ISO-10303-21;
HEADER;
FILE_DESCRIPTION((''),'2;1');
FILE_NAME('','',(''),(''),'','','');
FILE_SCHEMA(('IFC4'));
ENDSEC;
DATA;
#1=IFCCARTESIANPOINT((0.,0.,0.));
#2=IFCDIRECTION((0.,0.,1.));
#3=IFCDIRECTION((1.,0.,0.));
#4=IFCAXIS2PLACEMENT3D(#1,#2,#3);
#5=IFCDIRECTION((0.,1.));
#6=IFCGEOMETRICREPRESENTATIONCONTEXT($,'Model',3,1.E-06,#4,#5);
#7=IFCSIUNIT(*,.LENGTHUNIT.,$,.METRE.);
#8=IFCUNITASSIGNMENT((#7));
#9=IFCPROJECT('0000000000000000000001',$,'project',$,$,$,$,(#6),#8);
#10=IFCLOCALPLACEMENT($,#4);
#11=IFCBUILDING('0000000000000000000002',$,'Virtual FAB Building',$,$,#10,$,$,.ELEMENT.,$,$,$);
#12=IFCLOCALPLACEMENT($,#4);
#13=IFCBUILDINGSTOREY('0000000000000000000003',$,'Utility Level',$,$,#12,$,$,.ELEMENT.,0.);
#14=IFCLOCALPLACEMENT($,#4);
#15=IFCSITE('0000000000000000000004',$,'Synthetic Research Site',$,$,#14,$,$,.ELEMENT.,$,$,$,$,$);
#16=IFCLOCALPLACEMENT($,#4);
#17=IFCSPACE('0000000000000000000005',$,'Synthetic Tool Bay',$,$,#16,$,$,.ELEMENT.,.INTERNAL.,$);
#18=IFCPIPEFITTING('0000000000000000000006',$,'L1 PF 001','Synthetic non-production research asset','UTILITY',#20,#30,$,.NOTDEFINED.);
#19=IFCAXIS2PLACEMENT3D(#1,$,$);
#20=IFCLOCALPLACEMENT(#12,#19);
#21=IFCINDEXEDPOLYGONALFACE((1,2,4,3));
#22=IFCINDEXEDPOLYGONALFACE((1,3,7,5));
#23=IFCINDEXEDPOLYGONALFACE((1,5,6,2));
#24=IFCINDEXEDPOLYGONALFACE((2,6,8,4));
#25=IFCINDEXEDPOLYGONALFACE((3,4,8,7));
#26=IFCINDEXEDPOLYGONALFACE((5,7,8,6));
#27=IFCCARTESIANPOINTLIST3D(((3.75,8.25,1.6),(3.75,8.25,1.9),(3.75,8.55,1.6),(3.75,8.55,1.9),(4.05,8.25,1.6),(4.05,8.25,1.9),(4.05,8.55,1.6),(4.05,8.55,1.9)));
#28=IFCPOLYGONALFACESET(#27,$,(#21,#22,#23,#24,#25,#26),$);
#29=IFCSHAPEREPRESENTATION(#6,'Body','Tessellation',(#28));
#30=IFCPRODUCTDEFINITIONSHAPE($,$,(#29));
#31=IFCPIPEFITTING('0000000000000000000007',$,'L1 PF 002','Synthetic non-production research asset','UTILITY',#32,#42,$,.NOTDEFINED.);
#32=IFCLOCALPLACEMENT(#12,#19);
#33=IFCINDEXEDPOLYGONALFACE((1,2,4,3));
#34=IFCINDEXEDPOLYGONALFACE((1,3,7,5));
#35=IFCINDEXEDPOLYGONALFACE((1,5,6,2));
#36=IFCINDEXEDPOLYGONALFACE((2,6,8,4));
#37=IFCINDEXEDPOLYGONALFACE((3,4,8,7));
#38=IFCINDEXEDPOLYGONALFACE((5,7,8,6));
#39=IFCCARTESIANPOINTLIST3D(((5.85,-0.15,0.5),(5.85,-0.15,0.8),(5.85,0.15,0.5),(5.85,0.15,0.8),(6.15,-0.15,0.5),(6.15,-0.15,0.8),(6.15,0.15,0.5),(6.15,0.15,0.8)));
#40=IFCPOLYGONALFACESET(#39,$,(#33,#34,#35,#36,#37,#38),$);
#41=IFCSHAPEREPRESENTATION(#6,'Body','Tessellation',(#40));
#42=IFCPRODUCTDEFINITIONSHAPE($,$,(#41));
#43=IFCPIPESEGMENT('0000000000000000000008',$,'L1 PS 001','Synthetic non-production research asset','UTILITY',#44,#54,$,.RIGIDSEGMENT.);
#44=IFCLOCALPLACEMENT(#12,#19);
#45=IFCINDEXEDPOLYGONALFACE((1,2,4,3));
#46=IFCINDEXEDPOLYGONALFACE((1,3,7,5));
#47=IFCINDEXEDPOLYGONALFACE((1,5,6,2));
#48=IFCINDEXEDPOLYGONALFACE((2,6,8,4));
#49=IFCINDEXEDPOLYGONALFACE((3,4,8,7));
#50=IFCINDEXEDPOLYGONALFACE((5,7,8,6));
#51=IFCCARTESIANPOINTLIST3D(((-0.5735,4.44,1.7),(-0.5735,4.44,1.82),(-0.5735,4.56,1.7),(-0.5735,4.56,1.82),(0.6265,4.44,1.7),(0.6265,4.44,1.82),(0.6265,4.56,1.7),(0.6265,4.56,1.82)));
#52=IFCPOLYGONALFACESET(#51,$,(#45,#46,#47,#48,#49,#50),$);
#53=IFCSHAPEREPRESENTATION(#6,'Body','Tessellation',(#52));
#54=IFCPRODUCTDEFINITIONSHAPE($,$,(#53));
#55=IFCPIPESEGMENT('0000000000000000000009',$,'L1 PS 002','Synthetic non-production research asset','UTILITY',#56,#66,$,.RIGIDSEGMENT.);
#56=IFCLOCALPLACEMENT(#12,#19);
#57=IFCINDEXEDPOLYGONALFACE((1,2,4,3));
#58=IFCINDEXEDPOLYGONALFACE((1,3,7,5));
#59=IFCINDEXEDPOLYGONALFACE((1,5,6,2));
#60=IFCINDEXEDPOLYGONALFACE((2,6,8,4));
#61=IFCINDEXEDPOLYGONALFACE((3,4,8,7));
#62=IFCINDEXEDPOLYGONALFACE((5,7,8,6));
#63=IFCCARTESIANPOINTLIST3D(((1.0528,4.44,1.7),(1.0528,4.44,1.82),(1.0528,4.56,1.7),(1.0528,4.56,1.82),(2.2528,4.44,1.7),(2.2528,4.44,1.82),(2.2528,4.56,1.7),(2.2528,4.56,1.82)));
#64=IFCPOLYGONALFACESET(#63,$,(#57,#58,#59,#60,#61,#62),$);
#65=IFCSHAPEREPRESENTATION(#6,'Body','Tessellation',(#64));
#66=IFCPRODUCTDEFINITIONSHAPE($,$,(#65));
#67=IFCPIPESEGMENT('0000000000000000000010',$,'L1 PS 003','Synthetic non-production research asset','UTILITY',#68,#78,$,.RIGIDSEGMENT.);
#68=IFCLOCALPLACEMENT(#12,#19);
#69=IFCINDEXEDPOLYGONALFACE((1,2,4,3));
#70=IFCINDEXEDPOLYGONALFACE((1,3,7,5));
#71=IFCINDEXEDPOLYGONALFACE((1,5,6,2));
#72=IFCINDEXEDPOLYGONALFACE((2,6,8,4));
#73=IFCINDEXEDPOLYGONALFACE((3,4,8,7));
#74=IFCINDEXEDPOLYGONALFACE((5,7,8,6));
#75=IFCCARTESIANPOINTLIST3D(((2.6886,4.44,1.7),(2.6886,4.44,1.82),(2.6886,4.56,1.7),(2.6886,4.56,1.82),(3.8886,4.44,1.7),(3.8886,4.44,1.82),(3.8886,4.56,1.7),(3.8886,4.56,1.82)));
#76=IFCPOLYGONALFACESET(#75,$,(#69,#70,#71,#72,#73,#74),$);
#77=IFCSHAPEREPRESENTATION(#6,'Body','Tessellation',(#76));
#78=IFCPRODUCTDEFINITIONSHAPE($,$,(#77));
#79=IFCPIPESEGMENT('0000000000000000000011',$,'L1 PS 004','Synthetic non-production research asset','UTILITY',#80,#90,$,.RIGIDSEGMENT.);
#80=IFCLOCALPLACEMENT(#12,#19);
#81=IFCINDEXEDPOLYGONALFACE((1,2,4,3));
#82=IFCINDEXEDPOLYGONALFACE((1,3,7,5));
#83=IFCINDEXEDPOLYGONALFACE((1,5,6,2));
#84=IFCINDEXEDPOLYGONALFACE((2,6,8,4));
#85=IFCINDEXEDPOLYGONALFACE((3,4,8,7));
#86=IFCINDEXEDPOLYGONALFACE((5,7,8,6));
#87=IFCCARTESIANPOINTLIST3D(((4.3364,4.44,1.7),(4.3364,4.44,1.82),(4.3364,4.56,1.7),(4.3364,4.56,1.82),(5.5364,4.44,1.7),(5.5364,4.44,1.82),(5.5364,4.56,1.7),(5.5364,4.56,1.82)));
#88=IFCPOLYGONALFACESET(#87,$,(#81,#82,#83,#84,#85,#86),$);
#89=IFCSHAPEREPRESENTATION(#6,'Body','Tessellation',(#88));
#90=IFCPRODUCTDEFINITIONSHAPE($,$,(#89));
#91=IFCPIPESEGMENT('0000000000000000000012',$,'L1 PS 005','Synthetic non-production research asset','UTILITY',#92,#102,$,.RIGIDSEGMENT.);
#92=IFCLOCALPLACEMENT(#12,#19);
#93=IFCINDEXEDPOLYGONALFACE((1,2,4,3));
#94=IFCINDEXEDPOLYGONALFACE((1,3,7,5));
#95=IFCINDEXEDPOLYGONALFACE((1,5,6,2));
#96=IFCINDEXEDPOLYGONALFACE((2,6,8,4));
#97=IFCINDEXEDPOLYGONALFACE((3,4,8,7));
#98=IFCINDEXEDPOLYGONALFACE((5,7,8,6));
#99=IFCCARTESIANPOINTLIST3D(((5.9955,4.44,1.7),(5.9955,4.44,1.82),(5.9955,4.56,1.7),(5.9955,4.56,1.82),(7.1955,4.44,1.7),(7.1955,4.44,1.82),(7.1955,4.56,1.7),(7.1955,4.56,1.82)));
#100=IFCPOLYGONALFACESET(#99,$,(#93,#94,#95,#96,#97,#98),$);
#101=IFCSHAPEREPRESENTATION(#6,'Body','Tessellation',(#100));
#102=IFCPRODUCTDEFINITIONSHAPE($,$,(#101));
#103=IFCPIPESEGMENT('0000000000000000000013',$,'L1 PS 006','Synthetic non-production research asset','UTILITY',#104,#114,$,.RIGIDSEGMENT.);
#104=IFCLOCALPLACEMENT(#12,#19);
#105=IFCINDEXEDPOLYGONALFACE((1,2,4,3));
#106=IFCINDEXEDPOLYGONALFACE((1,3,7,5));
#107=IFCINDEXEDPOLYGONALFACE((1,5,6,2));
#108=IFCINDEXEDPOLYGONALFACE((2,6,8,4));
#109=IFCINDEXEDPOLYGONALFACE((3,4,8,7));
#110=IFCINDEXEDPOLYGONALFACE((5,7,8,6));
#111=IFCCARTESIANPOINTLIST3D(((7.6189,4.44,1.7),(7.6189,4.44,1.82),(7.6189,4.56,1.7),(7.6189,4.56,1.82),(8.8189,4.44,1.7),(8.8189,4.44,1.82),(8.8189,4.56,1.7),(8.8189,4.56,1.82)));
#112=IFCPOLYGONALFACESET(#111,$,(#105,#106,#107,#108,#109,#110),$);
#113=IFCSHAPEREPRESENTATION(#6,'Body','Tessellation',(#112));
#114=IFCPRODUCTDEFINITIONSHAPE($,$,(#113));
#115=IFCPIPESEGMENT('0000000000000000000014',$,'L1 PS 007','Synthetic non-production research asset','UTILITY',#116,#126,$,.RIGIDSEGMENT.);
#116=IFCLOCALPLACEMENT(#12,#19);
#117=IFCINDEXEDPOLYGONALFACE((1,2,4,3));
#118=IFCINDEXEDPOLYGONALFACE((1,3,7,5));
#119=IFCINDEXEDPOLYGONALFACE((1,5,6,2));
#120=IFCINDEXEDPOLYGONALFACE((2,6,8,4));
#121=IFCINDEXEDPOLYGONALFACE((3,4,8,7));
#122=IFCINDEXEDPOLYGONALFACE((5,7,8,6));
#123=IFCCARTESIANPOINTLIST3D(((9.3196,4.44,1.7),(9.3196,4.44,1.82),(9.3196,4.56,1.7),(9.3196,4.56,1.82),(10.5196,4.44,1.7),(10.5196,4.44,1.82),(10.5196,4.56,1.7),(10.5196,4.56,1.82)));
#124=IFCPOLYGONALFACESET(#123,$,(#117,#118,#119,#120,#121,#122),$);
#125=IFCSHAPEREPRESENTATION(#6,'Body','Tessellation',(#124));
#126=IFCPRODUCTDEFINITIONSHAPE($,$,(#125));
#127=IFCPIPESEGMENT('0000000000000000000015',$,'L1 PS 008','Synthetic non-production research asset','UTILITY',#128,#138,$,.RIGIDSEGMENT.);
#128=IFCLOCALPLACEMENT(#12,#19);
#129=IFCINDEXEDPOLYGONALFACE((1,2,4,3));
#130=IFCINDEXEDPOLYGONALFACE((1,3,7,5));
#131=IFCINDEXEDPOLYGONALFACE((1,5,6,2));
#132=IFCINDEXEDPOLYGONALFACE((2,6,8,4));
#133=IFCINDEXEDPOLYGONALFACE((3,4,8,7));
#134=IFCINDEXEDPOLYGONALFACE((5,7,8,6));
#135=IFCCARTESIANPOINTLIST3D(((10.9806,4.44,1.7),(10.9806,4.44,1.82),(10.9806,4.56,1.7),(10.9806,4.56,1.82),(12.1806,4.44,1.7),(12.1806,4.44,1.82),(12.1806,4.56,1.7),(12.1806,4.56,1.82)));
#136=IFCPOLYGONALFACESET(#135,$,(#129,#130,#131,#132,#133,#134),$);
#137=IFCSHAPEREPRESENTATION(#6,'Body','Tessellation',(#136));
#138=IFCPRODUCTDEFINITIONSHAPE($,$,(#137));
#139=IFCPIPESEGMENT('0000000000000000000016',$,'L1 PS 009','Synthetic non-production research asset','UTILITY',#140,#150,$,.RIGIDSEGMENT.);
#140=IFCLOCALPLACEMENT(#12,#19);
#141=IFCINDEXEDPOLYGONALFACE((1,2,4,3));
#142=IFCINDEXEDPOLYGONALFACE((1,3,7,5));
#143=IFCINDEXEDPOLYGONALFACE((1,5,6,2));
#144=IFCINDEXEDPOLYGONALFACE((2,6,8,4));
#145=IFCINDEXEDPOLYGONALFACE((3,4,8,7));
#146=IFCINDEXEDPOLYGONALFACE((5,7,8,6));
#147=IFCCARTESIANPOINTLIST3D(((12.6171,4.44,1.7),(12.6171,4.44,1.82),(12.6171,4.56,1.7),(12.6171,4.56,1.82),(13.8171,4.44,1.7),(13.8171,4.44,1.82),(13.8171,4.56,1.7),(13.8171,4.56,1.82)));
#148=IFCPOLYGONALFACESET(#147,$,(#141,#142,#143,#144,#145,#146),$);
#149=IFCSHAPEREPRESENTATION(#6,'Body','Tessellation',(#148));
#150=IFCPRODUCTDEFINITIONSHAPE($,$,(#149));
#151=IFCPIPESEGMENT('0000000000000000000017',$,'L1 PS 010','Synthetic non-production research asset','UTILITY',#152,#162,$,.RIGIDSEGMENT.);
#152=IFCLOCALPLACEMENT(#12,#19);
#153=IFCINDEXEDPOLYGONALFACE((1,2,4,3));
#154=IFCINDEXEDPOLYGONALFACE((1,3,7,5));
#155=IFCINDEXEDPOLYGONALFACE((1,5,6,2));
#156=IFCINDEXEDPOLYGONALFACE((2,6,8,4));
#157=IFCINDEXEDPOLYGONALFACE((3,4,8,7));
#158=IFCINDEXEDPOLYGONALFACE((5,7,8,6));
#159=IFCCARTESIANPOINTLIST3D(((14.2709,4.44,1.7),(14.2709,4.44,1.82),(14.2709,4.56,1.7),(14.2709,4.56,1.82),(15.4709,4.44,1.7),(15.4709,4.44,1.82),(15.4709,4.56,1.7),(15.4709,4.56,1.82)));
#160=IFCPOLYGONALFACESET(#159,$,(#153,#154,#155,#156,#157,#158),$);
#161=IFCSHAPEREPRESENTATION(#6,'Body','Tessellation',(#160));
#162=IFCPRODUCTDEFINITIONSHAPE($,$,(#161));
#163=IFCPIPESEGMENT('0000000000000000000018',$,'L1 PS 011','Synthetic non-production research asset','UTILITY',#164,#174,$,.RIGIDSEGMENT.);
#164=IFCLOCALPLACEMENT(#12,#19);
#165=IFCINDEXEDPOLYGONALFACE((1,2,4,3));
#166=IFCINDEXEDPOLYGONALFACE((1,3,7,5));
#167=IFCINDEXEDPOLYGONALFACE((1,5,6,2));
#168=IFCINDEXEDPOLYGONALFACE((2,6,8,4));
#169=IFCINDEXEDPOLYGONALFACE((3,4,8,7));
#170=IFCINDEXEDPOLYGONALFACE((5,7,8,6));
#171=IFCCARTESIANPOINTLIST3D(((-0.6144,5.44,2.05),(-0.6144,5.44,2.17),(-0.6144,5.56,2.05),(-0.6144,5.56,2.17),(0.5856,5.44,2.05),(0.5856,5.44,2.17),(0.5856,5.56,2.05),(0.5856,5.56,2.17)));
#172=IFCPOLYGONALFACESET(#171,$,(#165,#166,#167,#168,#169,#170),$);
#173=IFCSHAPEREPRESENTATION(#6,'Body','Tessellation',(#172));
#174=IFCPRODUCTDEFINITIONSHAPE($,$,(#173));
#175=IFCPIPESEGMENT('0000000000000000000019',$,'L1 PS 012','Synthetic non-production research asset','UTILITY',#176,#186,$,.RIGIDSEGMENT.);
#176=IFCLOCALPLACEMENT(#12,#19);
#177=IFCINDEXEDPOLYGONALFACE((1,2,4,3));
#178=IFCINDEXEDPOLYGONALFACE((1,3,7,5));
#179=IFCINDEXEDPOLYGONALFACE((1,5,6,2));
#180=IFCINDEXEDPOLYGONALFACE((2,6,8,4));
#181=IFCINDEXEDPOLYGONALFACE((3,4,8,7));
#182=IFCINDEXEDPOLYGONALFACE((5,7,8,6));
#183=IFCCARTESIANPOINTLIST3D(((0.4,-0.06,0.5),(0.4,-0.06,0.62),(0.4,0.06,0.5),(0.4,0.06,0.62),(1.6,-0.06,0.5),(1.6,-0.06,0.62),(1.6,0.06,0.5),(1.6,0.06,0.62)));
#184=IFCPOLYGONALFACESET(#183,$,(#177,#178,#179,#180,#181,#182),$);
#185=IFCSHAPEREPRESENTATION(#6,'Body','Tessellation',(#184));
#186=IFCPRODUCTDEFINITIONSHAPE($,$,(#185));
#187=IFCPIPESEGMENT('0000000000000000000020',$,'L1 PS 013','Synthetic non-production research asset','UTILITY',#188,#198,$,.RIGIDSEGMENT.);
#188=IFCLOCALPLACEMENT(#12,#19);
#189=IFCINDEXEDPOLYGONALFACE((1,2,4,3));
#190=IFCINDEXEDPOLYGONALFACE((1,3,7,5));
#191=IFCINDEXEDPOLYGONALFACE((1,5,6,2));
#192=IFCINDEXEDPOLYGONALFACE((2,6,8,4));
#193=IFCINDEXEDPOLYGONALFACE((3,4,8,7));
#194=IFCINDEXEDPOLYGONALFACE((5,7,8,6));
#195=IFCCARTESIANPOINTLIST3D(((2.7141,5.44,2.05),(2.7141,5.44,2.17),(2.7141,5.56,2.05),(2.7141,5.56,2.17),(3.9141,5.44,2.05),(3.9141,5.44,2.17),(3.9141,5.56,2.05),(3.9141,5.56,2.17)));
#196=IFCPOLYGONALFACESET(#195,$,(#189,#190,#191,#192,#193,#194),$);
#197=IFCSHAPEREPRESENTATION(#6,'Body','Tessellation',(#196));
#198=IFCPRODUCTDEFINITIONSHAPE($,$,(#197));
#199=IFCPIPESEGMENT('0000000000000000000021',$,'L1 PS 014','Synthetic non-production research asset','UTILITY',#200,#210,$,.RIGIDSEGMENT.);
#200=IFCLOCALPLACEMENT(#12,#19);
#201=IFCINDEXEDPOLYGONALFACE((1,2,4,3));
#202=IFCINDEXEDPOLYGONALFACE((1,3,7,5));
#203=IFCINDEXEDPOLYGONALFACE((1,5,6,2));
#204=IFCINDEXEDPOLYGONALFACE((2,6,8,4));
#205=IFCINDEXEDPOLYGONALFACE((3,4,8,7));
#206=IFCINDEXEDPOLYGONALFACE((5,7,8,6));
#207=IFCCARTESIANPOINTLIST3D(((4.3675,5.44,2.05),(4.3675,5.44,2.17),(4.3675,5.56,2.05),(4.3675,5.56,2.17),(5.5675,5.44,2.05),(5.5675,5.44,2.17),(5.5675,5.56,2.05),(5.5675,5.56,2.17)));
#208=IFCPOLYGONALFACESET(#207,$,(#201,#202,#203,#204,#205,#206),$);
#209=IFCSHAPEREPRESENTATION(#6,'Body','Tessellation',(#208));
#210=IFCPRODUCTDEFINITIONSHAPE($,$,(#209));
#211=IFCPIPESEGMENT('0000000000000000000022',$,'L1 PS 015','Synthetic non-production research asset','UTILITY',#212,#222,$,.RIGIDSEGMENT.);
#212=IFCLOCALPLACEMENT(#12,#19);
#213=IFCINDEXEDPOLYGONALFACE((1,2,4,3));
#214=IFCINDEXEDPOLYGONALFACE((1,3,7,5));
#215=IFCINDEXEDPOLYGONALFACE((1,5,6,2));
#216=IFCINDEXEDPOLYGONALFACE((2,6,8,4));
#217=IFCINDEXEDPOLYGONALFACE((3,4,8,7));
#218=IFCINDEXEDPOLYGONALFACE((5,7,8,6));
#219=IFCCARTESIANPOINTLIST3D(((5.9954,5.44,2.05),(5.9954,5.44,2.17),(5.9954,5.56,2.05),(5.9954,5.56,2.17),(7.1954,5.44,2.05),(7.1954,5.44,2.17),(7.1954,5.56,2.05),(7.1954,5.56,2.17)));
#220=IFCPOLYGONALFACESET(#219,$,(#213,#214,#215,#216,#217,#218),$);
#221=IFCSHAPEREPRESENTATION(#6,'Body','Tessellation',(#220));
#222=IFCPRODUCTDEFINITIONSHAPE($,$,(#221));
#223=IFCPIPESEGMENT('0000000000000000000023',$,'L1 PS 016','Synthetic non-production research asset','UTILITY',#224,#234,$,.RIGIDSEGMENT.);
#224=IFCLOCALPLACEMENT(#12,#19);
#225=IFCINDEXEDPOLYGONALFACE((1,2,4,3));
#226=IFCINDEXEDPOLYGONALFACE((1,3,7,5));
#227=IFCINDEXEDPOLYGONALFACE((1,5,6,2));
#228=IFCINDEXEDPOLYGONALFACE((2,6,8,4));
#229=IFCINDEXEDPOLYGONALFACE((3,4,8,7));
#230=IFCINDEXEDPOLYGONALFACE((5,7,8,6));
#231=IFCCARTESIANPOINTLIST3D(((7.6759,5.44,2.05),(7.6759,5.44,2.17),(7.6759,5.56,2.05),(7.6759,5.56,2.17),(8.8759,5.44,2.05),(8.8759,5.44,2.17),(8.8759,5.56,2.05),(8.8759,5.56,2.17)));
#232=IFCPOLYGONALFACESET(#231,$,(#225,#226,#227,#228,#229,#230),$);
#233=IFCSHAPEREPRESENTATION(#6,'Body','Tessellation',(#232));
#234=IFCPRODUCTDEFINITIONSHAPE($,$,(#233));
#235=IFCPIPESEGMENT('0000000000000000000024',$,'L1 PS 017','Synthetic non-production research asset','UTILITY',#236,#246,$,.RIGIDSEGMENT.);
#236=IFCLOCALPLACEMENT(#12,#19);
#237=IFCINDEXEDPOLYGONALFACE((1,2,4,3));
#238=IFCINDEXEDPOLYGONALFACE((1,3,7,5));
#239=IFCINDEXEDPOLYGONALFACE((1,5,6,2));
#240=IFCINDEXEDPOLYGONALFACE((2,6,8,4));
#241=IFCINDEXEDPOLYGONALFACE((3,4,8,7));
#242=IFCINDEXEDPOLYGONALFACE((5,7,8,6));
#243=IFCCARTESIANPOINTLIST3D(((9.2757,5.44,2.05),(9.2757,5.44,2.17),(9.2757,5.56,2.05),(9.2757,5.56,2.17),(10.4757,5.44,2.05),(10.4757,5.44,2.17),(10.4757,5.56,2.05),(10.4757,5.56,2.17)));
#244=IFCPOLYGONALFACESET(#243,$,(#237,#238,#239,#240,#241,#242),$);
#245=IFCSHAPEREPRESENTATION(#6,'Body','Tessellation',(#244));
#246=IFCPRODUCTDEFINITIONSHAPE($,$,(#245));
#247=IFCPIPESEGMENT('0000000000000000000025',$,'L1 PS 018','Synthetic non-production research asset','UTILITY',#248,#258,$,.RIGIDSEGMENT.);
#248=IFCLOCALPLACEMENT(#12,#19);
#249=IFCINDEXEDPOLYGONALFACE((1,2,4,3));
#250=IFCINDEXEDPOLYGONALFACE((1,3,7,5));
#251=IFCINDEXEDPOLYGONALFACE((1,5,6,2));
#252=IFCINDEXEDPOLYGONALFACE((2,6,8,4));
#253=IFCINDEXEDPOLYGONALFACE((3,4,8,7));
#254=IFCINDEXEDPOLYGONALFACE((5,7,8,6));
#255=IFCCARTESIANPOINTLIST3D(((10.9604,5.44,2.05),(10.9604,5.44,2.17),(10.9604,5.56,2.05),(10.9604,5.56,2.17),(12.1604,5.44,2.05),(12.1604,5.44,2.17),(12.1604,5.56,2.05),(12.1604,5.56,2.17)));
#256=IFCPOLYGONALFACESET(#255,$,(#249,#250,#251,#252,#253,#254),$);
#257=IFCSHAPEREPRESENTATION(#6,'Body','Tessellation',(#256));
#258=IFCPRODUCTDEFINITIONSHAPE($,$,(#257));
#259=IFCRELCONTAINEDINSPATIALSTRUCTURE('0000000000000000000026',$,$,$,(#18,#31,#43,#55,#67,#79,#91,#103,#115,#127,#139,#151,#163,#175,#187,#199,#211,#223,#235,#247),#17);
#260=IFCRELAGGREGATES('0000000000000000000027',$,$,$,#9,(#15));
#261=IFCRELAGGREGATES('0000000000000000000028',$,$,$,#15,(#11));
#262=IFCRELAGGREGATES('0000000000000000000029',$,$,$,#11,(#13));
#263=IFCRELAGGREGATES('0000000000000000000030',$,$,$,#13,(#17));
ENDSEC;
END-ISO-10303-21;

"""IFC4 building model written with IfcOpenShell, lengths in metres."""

from ifc_helpers import new_model, si_unit, direction, frame, origin_with_axes, origin_2d_with_axis, place, context, project, spatial, rectangle, extrude, element, save


model = new_model("IFC4")

# Units and contexts
model_context = context("Model", 3, precision=1e-06, world=origin_with_axes(), true_north=direction((0.0, 1.0)))
ifc_project = project(units=[si_unit("LENGTHUNIT", "METRE")], contexts=[model_context])

# Site, building, storey, space
site_placement = place(None, origin_with_axes())
site = spatial("IfcSite", under=ifc_project, at=site_placement, Name="Synthetic Research Site", CompositionType="ELEMENT")
building_placement = place(None, origin_with_axes())
building = spatial("IfcBuilding", under=site, at=building_placement, Name="Virtual FAB Building", CompositionType="ELEMENT")
storey_placement = place(None, origin_with_axes())
storey = spatial("IfcBuildingStorey", under=building, at=storey_placement, Name="Utility Level", CompositionType="ELEMENT", Elevation=0.0)
space_placement = place(None, origin_with_axes())
space = spatial("IfcSpace", under=storey, at=space_placement, Name="Synthetic Tool Bay", CompositionType="ELEMENT", PredefinedType="INTERNAL")

# Pipe fittings
for number, where, z_axis, x_axis, name in (
    (1, (3.9, 8.4, 1.6), (0.0, 0.0, 1.0), (1.0, 0.0, 0.0), "L1 PF 001"),
    (2, (6.0, 0.0, 0.5), (0.0, 0.0, 1.0), (1.0, 0.0, 0.0), "L1 PF 002"),
):
    element("IfcPipeFitting", number, at=place(None, frame(where, z_axis=z_axis, x_axis=x_axis)), inside=space, Name=name, Description="Synthetic non-production research asset", ObjectType="UTILITY", PredefinedType="NOTDEFINED", context=model_context, shape_type="SweptSolid", body=[
        extrude(rectangle(XDim=0.3, YDim=0.3, at=origin_2d_with_axis()), origin_with_axes(), (0.0, 0.0, 1.0), 0.3),
    ])

# Pipe segments
for number, where, z_axis, x_axis, name in (
    (3, (0.0265, 4.5, 1.7), (0.0, 0.0, 1.0), (1.0, 0.0, 0.0), "L1 PS 001"),
    (4, (1.6528, 4.5, 1.7), (0.0, 0.0, 1.0), (1.0, 0.0, 0.0), "L1 PS 002"),
    (5, (3.2886, 4.5, 1.7), (0.0, 0.0, 1.0), (1.0, 0.0, 0.0), "L1 PS 003"),
    (6, (4.9364, 4.5, 1.7), (0.0, 0.0, 1.0), (1.0, 0.0, 0.0), "L1 PS 004"),
    (7, (6.5955, 4.5, 1.7), (0.0, 0.0, 1.0), (1.0, 0.0, 0.0), "L1 PS 005"),
    (8, (8.2189, 4.5, 1.7), (0.0, 0.0, 1.0), (1.0, 0.0, 0.0), "L1 PS 006"),
    (9, (9.9196, 4.5, 1.7), (0.0, 0.0, 1.0), (1.0, 0.0, 0.0), "L1 PS 007"),
    (10, (11.5806, 4.5, 1.7), (0.0, 0.0, 1.0), (1.0, 0.0, 0.0), "L1 PS 008"),
    (11, (13.2171, 4.5, 1.7), (0.0, 0.0, 1.0), (1.0, 0.0, 0.0), "L1 PS 009"),
    (12, (14.8709, 4.5, 1.7), (0.0, 0.0, 1.0), (1.0, 0.0, 0.0), "L1 PS 010"),
    (13, (-0.0144, 5.5, 2.05), (0.0, 0.0, 1.0), (1.0, 0.0, 0.0), "L1 PS 011"),
    (14, (1.0, 0.0, 0.5), (0.0, 0.0, 1.0), (1.0, 0.0, 0.0), "L1 PS 012"),
    (15, (3.3141, 5.5, 2.05), (0.0, 0.0, 1.0), (1.0, 0.0, 0.0), "L1 PS 013"),
    (16, (4.9675, 5.5, 2.05), (0.0, 0.0, 1.0), (1.0, 0.0, 0.0), "L1 PS 014"),
    (17, (6.5954, 5.5, 2.05), (0.0, 0.0, 1.0), (1.0, 0.0, 0.0), "L1 PS 015"),
    (18, (8.2759, 5.5, 2.05), (0.0, 0.0, 1.0), (1.0, 0.0, 0.0), "L1 PS 016"),
    (19, (9.8757, 5.5, 2.05), (0.0, 0.0, 1.0), (1.0, 0.0, 0.0), "L1 PS 017"),
    (20, (11.5604, 5.5, 2.05), (0.0, 0.0, 1.0), (1.0, 0.0, 0.0), "L1 PS 018"),
):
    element("IfcPipeSegment", number, at=place(None, frame(where, z_axis=z_axis, x_axis=x_axis)), inside=space, Name=name, Description="Synthetic non-production research asset", ObjectType="UTILITY", PredefinedType="RIGIDSEGMENT", context=model_context, shape_type="SweptSolid", body=[
        extrude(rectangle(XDim=1.2, YDim=0.12, at=origin_2d_with_axis()), origin_with_axes(), (0.0, 0.0, 1.0), 0.12),
    ])

save(model, "model.ifc")
